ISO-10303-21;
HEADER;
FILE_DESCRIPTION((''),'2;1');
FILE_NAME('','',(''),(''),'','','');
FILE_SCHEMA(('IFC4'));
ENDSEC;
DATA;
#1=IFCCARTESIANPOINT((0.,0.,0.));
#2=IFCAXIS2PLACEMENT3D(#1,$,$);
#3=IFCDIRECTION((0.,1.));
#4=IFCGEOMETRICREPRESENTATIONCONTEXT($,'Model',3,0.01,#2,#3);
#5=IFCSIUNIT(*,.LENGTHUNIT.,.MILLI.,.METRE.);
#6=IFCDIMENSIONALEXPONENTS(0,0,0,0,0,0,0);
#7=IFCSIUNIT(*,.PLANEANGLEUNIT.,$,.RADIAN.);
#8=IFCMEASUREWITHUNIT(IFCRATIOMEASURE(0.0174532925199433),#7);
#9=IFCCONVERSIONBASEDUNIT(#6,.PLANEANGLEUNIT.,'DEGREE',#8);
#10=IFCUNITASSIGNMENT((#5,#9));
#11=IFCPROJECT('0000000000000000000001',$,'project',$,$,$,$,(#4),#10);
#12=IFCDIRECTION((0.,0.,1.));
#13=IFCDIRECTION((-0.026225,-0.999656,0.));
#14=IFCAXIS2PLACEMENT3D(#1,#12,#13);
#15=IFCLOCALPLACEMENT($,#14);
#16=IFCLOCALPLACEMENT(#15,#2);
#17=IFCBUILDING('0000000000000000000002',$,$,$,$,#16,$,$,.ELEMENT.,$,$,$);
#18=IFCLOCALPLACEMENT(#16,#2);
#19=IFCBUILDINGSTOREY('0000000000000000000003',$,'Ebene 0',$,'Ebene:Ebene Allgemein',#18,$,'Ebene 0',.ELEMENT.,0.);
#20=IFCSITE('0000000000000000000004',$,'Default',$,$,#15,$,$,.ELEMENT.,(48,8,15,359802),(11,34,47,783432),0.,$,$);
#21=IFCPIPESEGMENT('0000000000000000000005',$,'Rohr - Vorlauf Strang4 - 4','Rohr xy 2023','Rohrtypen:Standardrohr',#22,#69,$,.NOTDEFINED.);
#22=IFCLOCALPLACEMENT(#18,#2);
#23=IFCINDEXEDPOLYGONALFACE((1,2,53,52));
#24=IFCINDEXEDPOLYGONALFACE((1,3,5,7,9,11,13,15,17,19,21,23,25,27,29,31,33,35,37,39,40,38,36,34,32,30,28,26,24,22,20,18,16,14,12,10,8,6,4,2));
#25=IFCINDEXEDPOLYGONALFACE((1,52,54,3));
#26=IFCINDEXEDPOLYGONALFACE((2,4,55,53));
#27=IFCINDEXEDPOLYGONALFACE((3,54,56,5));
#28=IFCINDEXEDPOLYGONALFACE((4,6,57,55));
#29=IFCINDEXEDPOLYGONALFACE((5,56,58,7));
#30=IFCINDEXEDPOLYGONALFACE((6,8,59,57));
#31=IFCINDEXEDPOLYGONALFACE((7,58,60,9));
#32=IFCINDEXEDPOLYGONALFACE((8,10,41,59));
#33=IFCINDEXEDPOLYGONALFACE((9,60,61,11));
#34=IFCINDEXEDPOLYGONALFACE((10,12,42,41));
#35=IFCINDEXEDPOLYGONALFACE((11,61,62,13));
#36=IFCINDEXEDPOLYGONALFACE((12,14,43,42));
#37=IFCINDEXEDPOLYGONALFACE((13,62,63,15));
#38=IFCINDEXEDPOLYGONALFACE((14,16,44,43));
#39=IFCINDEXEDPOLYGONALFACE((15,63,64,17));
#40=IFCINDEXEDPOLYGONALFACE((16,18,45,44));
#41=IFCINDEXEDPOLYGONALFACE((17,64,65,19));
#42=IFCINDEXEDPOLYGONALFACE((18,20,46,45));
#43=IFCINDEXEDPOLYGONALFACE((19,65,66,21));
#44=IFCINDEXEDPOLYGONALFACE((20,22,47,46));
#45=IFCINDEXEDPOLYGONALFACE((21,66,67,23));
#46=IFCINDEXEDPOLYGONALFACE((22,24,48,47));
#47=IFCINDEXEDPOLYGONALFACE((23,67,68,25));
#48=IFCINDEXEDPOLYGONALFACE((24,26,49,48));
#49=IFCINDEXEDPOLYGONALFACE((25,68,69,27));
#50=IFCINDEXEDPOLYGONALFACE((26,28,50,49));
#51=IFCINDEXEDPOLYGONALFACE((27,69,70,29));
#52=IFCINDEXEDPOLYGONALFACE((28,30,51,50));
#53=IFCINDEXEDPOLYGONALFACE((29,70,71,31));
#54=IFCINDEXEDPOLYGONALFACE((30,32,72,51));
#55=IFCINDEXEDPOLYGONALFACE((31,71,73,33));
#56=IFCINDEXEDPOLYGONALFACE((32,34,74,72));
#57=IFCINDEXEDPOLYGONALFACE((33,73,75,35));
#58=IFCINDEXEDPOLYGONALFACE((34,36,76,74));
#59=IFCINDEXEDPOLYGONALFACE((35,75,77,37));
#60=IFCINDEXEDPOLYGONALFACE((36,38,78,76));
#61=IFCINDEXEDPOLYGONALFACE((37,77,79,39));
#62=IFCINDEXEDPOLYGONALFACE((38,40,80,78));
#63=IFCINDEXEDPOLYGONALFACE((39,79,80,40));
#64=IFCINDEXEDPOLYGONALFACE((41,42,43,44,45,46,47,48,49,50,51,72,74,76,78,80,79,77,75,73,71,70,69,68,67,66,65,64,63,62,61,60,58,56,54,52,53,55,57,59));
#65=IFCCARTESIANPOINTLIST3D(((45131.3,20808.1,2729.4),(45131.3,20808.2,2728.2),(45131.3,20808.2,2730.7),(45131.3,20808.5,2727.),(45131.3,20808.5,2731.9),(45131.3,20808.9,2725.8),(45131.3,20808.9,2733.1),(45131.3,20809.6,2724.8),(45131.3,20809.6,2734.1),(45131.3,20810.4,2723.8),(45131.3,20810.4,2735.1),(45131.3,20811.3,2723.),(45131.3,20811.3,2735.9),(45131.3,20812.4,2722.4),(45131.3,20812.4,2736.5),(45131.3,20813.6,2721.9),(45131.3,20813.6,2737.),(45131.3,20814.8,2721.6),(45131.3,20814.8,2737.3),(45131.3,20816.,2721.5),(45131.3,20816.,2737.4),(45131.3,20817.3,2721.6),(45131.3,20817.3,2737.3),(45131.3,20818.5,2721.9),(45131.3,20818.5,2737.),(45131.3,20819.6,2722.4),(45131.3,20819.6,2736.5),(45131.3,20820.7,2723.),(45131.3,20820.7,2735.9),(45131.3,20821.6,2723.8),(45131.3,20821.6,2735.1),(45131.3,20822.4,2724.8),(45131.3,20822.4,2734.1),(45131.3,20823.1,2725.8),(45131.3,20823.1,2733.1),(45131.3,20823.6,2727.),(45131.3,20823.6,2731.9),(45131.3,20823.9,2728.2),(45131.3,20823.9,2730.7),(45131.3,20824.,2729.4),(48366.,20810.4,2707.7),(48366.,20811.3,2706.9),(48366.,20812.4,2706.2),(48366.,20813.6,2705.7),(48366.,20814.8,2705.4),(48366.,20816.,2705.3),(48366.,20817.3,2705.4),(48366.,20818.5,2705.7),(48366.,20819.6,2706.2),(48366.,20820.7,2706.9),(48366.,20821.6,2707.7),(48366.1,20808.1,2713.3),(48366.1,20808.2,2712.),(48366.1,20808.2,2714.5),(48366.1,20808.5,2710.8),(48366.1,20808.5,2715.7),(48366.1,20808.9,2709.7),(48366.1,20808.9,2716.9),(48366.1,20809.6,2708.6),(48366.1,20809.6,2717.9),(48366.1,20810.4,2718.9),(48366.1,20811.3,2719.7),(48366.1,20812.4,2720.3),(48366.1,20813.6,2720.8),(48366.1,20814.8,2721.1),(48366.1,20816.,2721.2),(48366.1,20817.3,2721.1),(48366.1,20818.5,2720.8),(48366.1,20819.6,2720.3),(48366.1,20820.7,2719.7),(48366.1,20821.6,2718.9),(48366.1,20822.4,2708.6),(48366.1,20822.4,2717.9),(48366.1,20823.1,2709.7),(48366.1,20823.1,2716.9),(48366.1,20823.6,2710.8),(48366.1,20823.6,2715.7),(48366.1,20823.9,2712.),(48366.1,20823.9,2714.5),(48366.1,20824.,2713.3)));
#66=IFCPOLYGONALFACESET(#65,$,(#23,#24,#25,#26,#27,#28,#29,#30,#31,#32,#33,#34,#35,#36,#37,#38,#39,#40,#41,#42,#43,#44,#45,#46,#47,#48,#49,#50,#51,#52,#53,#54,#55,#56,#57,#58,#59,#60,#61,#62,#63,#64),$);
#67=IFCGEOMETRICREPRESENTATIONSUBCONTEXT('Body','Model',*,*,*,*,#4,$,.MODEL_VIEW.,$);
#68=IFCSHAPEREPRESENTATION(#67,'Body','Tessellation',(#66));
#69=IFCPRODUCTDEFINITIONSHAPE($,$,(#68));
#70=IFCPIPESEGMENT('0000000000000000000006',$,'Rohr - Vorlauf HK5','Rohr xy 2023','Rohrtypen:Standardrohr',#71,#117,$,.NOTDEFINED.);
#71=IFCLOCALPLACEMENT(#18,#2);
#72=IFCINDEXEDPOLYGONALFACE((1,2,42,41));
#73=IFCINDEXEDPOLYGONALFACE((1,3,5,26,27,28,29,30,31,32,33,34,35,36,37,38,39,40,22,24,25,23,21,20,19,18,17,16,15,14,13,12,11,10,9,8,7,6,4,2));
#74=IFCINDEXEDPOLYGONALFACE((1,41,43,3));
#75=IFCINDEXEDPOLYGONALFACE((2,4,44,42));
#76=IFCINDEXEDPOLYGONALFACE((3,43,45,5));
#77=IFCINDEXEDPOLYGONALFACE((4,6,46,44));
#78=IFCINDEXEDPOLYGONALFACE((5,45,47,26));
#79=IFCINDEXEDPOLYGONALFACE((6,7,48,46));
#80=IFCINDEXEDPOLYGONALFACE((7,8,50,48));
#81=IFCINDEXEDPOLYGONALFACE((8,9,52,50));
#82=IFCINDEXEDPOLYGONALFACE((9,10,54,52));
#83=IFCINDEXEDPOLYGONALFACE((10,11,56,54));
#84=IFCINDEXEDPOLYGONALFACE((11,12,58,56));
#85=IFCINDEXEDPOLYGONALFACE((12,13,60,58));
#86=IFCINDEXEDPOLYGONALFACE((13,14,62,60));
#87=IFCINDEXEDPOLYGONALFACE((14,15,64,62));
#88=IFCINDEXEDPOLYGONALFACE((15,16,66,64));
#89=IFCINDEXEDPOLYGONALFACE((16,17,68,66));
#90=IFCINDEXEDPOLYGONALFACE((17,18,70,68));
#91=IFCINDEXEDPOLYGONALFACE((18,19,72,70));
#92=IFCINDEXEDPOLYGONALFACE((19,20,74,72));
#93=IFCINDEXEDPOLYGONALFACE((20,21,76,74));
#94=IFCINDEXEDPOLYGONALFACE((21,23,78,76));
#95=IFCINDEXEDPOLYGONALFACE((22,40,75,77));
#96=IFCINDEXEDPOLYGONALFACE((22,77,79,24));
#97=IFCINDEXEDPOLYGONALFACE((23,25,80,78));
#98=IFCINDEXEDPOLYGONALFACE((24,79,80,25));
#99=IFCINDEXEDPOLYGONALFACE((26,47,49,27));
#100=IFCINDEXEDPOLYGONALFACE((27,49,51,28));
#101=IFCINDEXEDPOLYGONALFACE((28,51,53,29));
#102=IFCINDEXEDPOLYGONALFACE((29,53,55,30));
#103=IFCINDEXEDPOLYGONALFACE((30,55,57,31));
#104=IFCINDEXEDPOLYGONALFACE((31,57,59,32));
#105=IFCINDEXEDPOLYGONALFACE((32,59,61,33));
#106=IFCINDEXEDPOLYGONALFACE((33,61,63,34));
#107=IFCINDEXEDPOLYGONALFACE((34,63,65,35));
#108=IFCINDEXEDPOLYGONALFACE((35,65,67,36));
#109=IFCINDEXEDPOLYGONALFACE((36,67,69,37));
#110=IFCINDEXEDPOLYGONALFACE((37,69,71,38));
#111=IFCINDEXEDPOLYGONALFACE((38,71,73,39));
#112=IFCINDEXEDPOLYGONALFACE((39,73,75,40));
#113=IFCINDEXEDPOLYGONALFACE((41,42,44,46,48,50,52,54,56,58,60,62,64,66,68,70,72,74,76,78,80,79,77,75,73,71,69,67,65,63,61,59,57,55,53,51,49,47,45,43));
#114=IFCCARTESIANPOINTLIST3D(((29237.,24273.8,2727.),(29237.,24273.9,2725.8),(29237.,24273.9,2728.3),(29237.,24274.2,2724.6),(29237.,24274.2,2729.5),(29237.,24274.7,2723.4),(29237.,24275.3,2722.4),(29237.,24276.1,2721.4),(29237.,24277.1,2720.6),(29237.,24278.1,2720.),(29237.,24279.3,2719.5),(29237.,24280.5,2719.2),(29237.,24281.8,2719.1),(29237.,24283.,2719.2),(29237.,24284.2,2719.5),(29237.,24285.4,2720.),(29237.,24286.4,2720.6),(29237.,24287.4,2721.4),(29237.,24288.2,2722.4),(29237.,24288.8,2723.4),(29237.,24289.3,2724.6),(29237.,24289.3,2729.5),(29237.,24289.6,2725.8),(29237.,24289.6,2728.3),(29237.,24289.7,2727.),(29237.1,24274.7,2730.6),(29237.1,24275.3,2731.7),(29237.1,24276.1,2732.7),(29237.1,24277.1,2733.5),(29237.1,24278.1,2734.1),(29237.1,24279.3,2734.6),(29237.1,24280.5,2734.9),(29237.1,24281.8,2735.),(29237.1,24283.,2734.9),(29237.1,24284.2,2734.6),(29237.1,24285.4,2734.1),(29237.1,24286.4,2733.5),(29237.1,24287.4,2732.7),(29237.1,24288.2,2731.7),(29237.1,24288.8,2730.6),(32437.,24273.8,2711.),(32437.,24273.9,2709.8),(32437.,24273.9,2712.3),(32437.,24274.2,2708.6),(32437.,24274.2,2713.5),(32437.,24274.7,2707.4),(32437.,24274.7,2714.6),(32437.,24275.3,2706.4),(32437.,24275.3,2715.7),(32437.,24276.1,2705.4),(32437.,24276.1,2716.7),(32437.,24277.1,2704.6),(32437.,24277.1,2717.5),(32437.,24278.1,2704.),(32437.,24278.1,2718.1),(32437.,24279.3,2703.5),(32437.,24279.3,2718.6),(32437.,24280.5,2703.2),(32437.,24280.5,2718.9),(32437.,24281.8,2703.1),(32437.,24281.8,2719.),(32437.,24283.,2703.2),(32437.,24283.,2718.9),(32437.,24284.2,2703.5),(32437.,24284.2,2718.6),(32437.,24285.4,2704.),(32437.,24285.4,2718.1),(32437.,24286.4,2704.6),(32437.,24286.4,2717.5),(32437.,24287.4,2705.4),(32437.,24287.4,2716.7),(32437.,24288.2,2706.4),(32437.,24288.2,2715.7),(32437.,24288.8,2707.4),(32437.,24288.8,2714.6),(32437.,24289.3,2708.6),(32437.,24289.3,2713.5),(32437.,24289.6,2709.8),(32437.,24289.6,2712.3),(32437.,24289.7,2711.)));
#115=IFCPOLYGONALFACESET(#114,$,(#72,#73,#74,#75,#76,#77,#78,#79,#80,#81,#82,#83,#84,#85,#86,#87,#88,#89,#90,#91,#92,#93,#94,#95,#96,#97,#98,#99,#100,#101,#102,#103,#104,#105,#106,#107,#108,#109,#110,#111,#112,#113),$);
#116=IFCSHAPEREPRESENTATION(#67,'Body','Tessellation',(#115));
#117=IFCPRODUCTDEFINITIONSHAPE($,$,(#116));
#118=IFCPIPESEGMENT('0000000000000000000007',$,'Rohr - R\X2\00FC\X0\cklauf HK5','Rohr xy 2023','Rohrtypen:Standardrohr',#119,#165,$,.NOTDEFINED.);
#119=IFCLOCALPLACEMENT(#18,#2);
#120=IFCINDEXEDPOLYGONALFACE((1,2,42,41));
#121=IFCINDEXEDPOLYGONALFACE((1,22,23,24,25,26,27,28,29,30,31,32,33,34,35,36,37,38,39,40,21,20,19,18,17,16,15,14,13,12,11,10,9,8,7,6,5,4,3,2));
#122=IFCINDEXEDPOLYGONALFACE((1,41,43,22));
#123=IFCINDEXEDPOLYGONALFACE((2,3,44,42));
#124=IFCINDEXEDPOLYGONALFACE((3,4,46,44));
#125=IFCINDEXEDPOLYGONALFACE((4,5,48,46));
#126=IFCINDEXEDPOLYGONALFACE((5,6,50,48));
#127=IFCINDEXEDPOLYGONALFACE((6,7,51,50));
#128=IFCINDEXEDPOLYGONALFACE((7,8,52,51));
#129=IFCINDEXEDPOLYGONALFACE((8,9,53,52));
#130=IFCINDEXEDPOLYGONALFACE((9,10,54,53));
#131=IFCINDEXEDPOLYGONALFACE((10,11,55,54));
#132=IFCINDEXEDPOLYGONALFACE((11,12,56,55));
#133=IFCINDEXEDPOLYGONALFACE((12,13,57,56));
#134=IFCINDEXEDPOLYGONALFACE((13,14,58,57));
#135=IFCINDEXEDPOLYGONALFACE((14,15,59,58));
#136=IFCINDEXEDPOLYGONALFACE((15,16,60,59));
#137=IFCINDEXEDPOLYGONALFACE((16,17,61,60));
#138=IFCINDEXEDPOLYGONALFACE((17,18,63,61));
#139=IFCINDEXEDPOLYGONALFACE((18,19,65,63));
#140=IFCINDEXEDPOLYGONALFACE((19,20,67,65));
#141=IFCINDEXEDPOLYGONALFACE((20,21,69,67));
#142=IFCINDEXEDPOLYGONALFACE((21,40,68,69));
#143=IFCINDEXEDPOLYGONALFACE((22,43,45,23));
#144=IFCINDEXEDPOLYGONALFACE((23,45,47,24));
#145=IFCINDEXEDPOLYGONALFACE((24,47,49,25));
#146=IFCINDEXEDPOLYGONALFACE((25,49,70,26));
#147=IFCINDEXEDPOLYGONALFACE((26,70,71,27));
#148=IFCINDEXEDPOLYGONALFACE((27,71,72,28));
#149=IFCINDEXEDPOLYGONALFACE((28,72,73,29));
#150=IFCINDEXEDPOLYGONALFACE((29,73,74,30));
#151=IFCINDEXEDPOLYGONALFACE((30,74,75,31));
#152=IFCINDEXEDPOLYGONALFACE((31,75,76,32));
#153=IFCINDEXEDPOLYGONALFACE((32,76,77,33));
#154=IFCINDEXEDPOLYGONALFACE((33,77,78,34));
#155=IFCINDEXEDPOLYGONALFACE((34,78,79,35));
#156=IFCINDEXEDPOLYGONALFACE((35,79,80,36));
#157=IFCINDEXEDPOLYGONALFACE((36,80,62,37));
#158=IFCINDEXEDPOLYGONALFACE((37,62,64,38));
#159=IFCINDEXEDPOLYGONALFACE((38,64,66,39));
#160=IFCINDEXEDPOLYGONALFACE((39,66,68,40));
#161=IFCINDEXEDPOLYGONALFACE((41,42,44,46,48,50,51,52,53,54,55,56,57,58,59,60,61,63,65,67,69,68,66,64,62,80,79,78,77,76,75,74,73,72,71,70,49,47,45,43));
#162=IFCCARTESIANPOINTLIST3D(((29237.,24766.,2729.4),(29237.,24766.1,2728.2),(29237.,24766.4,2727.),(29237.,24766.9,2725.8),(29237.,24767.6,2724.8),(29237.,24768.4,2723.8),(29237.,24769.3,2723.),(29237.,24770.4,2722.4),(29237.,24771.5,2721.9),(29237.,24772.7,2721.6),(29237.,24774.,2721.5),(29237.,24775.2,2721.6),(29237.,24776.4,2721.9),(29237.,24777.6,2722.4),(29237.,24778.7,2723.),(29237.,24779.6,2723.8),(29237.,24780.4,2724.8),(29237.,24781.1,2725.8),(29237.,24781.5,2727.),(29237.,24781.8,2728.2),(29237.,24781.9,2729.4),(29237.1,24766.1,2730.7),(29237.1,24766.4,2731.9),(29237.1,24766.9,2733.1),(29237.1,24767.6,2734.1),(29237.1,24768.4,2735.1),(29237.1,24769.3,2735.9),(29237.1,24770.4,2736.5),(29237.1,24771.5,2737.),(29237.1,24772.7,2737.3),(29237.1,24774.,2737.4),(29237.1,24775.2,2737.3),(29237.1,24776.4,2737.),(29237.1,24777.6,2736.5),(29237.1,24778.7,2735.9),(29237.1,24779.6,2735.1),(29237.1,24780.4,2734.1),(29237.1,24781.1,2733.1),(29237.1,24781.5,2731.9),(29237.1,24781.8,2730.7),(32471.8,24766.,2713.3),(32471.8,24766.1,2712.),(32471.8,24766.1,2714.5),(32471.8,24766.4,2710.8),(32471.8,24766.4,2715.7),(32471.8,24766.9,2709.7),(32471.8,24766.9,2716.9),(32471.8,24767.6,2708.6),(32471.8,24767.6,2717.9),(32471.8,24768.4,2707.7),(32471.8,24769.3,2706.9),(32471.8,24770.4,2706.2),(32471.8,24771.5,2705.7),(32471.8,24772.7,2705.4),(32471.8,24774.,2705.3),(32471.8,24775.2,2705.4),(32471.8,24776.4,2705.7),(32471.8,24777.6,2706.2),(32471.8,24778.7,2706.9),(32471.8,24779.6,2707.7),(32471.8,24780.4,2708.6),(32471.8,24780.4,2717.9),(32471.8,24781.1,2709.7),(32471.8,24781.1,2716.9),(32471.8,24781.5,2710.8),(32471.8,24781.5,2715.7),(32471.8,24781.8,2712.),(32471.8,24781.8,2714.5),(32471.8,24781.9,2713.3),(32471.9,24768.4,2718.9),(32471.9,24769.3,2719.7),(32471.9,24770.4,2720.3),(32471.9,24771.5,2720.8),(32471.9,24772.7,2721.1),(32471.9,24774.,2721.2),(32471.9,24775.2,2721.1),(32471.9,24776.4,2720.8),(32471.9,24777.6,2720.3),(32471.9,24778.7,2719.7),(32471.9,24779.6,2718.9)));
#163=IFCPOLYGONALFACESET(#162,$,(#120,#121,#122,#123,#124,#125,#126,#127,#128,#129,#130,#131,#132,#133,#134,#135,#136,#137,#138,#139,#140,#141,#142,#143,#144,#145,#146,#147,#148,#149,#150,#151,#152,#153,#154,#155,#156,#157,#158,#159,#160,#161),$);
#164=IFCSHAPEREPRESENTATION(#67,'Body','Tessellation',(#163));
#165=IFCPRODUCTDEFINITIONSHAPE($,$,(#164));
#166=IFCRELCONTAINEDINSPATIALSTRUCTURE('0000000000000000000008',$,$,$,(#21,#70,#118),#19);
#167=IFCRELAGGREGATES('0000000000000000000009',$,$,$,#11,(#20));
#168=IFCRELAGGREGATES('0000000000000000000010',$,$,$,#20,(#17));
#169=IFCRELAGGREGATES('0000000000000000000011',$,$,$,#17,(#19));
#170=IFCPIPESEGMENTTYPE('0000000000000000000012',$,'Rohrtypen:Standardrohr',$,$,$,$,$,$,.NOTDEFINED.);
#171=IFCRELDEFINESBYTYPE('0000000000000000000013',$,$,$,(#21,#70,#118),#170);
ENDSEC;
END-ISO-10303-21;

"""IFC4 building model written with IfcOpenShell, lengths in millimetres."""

from ifc_helpers import new_model, entity, si_unit, converted_unit, direction, frame, origin, place, context, subcontext, project, spatial, indexed_curve, outline, extrude, type_object, element, save


model = new_model("IFC4")

# Units and contexts
model_context = context("Model", 3, precision=0.01, world=origin(), true_north=direction((0.0, 1.0)))
body_context = subcontext(model_context, "Body", "Model", "MODEL_VIEW")
ifc_project = project(units=[si_unit("LENGTHUNIT", "METRE", prefix="MILLI"), converted_unit("PLANEANGLEUNIT", "DEGREE", entity("IfcRatioMeasure", 0.0174532925199433), si_unit("PLANEANGLEUNIT", "RADIAN"), dimensions=[0, 0, 0, 0, 0, 0, 0])], contexts=[model_context])

# Site, building, storey
site_placement = place(None, frame((0.0, 0.0, 0.0), z_axis=(0.0, 0.0, 1.0), x_axis=(-0.026225, -0.999656, 0.0)))
site = spatial("IfcSite", under=ifc_project, at=site_placement, Name="Default", CompositionType="ELEMENT", RefLatitude=(48, 8, 15, 359802), RefLongitude=(11, 34, 47, 783432), RefElevation=0.0)
building_placement = place(site_placement, origin())
building = spatial("IfcBuilding", under=site, at=building_placement, CompositionType="ELEMENT")
storey_placement = place(building_placement, origin())
storey = spatial("IfcBuildingStorey", under=building, at=storey_placement, Name="Ebene 0", ObjectType="Ebene:Ebene Allgemein", LongName="Ebene 0", CompositionType="ELEMENT", Elevation=0.0)

# Pipe segments
pipe_segment_type = type_object("IfcPipeSegmentType", Name="Rohrtypen:Standardrohr", PredefinedType="NOTDEFINED")
pipe_segment_1_placement = place(storey_placement, origin())
element("IfcPipeSegment", 1, at=pipe_segment_1_placement, inside=storey, type_object=pipe_segment_type, Name="Rohr - Vorlauf Strang4 - 4", Description="Rohr xy 2023", ObjectType="Rohrtypen:Standardrohr", PredefinedType="NOTDEFINED", context=body_context, shape_type="SweptSolid", body=[
    extrude(outline(indexed_curve([(7.9, 0.0), (7.8, 1.2), (7.6, 2.5), (7.1, 3.6), (6.4, 4.7), (5.6, 5.6), (4.7, 6.4), (3.6, 7.1), (2.5, 7.6), (1.2, 7.8), (0.0, 7.9), (-1.2, 7.8), (-2.5, 7.6), (-3.6, 7.1), (-4.7, 6.4), (-5.6, 5.6), (-6.4, 4.7), (-7.1, 3.6), (-7.6, 2.5), (-7.8, 1.2), (-7.9, 0.0), (-7.8, -1.2), (-7.6, -2.5), (-7.1, -3.6), (-6.4, -4.7), (-5.6, -5.6), (-4.7, -6.4), (-3.6, -7.1), (-2.5, -7.6), (-1.2, -7.8), (0.0, -7.9), (1.2, -7.8), (2.5, -7.6), (3.6, -7.1), (4.7, -6.4), (5.6, -5.6), (6.4, -4.7), (7.1, -3.6), (7.6, -2.5), (7.8, -1.2), (7.9, 0.0)], self_intersect=False)), frame((48366.1, 20816.0, 2713.3), z_axis=(-0.999988, 0.0, 0.005), x_axis=(0.0, 1.0, 0.0)), (0.0, 0.0, 1.0), 3234.8),
])
pipe_segment_2_placement = place(storey_placement, origin())
element("IfcPipeSegment", 2, at=pipe_segment_2_placement, inside=storey, type_object=pipe_segment_type, Name="Rohr - Vorlauf HK5", Description="Rohr xy 2023", ObjectType="Rohrtypen:Standardrohr", PredefinedType="NOTDEFINED", context=body_context, shape_type="SweptSolid", body=[
    extrude(outline(indexed_curve([(7.9, 0.0), (7.8, 1.2), (7.6, 2.5), (7.1, 3.6), (6.4, 4.7), (5.6, 5.6), (4.7, 6.4), (3.6, 7.1), (2.5, 7.6), (1.2, 7.8), (0.0, 7.9), (-1.2, 7.8), (-2.5, 7.6), (-3.6, 7.1), (-4.7, 6.4), (-5.6, 5.6), (-6.4, 4.7), (-7.1, 3.6), (-7.6, 2.5), (-7.8, 1.2), (-7.9, 0.0), (-7.8, -1.2), (-7.6, -2.5), (-7.1, -3.6), (-6.4, -4.7), (-5.6, -5.6), (-4.7, -6.4), (-3.6, -7.1), (-2.5, -7.6), (-1.2, -7.8), (0.0, -7.9), (1.2, -7.8), (2.5, -7.6), (3.6, -7.1), (4.7, -6.4), (5.6, -5.6), (6.4, -4.7), (7.1, -3.6), (7.6, -2.5), (7.8, -1.2), (7.9, 0.0)], self_intersect=False)), frame((32437.0, 24281.8, 2711.0), z_axis=(-0.999988, 0.0, 0.005), x_axis=(0.0, 1.0, 0.0)), (0.0, 0.0, 1.0), 3200.0),
])
pipe_segment_3_placement = place(storey_placement, origin())
element("IfcPipeSegment", 3, at=pipe_segment_3_placement, inside=storey, type_object=pipe_segment_type, Name="Rohr - Rücklauf HK5", Description="Rohr xy 2023", ObjectType="Rohrtypen:Standardrohr", PredefinedType="NOTDEFINED", context=body_context, shape_type="SweptSolid", body=[
    extrude(outline(indexed_curve([(7.9, 0.0), (7.8, 1.2), (7.6, 2.5), (7.1, 3.6), (6.4, 4.7), (5.6, 5.6), (4.7, 6.4), (3.6, 7.1), (2.5, 7.6), (1.2, 7.8), (0.0, 7.9), (-1.2, 7.8), (-2.5, 7.6), (-3.6, 7.1), (-4.7, 6.4), (-5.6, 5.6), (-6.4, 4.7), (-7.1, 3.6), (-7.6, 2.5), (-7.8, 1.2), (-7.9, 0.0), (-7.8, -1.2), (-7.6, -2.5), (-7.1, -3.6), (-6.4, -4.7), (-5.6, -5.6), (-4.7, -6.4), (-3.6, -7.1), (-2.5, -7.6), (-1.2, -7.8), (0.0, -7.9), (1.2, -7.8), (2.5, -7.6), (3.6, -7.1), (4.7, -6.4), (5.6, -5.6), (6.4, -4.7), (7.1, -3.6), (7.6, -2.5), (7.8, -1.2), (7.9, 0.0)], self_intersect=False)), frame((32471.8, 24774.0, 2713.3), z_axis=(-0.999988, 0.0, 0.005), x_axis=(0.0, 1.0, 0.0)), (0.0, 0.0, 1.0), 3234.8),
])

save(model, "model.ifc")
